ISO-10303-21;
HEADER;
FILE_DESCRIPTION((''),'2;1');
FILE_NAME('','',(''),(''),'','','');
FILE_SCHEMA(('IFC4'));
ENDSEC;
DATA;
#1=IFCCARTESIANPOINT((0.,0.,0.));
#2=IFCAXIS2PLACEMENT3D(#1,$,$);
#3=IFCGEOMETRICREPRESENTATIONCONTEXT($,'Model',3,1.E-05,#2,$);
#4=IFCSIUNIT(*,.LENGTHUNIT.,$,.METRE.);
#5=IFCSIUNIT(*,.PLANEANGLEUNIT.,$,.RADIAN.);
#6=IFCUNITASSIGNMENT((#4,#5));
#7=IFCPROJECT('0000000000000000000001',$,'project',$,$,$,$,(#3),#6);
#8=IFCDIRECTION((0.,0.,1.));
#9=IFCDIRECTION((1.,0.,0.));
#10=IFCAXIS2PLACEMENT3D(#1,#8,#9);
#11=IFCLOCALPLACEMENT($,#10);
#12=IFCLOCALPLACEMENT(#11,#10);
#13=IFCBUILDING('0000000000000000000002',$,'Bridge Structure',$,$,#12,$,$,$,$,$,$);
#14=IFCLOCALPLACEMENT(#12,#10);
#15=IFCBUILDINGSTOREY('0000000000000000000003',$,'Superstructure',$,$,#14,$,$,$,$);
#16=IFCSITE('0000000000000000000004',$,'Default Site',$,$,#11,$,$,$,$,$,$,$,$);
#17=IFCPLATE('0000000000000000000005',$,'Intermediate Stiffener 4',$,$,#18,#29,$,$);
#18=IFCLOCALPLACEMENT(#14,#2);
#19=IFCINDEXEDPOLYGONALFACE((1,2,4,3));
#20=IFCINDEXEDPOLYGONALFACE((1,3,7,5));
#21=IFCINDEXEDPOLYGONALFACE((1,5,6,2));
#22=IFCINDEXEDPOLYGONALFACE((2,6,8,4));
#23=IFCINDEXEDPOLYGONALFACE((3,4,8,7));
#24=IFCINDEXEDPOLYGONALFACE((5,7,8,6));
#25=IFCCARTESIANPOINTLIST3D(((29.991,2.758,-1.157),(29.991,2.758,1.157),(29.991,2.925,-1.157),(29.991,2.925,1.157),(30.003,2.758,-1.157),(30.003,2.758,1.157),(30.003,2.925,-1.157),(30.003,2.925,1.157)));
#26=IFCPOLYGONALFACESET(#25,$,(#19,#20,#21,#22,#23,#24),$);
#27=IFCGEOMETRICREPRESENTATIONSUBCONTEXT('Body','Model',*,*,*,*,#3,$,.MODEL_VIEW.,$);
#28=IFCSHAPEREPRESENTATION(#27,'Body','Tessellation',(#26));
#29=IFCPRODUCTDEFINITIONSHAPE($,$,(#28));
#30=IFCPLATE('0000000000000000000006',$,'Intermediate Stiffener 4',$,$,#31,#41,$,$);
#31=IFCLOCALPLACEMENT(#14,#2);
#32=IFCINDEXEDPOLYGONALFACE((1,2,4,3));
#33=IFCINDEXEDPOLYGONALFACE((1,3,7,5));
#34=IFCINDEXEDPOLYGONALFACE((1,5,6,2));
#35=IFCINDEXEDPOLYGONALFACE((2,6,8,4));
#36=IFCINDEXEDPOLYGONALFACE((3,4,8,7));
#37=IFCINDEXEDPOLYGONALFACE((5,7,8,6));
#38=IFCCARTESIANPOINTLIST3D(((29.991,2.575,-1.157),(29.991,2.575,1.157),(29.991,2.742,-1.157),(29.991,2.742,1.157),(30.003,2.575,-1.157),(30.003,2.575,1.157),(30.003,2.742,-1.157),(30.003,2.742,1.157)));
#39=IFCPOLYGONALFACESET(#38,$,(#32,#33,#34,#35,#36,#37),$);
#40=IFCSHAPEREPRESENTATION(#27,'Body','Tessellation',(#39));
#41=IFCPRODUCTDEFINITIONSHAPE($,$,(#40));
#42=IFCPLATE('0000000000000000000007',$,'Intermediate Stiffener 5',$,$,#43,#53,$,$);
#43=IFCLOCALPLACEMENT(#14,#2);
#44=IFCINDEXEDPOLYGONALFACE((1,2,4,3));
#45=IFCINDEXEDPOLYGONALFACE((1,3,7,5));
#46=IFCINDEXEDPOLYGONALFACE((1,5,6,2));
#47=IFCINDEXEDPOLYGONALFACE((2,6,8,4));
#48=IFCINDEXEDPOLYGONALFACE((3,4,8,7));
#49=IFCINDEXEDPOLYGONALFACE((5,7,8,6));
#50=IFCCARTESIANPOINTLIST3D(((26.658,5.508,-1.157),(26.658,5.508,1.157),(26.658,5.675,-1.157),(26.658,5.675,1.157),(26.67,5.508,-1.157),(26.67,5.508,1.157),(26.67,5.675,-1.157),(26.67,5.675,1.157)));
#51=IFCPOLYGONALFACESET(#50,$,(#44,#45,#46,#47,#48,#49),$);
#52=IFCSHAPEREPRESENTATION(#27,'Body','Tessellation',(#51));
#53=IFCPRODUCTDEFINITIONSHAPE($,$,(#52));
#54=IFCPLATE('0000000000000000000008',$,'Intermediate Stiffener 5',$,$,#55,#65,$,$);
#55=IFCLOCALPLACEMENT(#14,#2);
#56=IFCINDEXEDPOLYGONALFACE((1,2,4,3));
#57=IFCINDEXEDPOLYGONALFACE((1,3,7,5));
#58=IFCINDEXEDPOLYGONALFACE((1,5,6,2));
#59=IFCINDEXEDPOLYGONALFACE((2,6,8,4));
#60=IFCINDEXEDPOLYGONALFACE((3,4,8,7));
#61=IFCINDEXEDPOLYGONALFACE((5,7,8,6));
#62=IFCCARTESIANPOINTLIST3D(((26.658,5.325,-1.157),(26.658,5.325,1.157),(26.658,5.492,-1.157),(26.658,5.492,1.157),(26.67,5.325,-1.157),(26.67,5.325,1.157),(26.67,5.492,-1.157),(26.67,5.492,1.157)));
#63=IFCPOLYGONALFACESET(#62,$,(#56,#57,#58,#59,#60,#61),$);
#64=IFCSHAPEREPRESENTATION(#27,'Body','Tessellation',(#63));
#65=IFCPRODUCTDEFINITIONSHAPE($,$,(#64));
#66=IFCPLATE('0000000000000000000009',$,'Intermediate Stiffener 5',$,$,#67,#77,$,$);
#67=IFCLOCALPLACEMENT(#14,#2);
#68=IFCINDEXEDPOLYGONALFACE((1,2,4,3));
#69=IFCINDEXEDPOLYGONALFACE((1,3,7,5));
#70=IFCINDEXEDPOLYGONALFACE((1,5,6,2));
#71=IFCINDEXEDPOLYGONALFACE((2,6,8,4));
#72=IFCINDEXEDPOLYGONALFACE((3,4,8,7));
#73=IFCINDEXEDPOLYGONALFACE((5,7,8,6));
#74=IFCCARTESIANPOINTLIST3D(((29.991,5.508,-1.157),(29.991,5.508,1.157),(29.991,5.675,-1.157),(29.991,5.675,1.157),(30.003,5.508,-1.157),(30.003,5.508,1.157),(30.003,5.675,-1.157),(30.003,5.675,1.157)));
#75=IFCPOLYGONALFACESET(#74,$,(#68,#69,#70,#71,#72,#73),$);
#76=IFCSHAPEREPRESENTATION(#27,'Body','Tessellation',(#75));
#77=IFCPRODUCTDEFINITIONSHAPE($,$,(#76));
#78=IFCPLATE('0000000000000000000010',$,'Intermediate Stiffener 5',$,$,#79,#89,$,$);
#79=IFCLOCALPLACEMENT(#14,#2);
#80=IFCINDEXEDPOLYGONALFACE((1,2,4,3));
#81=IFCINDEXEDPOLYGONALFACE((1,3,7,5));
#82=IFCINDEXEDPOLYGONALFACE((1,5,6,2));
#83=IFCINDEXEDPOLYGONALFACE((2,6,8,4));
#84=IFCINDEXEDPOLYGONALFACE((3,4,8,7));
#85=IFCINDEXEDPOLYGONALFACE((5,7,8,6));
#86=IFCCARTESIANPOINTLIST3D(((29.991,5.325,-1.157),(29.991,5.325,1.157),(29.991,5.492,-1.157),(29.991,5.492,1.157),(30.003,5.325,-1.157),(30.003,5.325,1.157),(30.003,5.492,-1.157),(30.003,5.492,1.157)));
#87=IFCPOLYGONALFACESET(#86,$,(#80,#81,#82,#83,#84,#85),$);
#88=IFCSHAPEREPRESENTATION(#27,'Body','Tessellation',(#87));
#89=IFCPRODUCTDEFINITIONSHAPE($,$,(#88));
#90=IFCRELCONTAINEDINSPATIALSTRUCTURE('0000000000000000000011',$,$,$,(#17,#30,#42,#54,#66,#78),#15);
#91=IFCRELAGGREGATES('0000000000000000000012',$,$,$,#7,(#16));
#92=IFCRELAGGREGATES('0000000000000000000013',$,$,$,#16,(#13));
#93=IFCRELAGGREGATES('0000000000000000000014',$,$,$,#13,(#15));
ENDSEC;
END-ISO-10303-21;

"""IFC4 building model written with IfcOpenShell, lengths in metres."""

from ifc_helpers import new_model, si_unit, frame, origin, origin_with_axes, origin_2d_with_axis, place, context, subcontext, project, spatial, rectangle, extrude, element, save


model = new_model("IFC4")

# Units and contexts
model_context = context("Model", 3, precision=1e-05, world=origin())
body_context = subcontext(model_context, "Body", "Model", "MODEL_VIEW")
ifc_project = project(units=[si_unit("LENGTHUNIT", "METRE"), si_unit("PLANEANGLEUNIT", "RADIAN")], contexts=[model_context])

# Site, building, storey
site_placement = place(None, origin_with_axes())
site = spatial("IfcSite", under=ifc_project, at=site_placement, Name="Default Site")
building_placement = place(site_placement, origin_with_axes())
building = spatial("IfcBuilding", under=site, at=building_placement, Name="Bridge Structure")
storey_placement = place(building_placement, origin_with_axes())
storey = spatial("IfcBuildingStorey", under=building, at=storey_placement, Name="Superstructure")

# Plates
for number, where, z_axis, x_axis, name in (
    (1, (29.997, 2.8415, -1.157), (0.0, 0.0, 1.0), (1.0, 0.0, 0.0), "Intermediate Stiffener 4"),
    (2, (29.997, 2.6585, -1.157), (0.0, 0.0, 1.0), (1.0, 0.0, 0.0), "Intermediate Stiffener 4"),
    (3, (26.664, 5.5915, -1.157), (0.0, 0.0, 1.0), (1.0, 0.0, 0.0), "Intermediate Stiffener 5"),
    (4, (26.664, 5.4085, -1.157), (0.0, 0.0, 1.0), (1.0, 0.0, 0.0), "Intermediate Stiffener 5"),
    (5, (29.997, 5.5915, -1.157), (0.0, 0.0, 1.0), (1.0, 0.0, 0.0), "Intermediate Stiffener 5"),
    (6, (29.997, 5.4085, -1.157), (0.0, 0.0, 1.0), (1.0, 0.0, 0.0), "Intermediate Stiffener 5"),
):
    element("IfcPlate", number, at=place(storey_placement, frame(where, z_axis=z_axis, x_axis=x_axis)), inside=storey, Name=name, context=body_context, shape_type="SweptSolid", body=[
        extrude(rectangle(XDim=0.012, YDim=0.167, at=origin_2d_with_axis()), origin_with_axes(), (0.0, 0.0, 1.0), 2.314),
    ])

save(model, "model.ifc")
